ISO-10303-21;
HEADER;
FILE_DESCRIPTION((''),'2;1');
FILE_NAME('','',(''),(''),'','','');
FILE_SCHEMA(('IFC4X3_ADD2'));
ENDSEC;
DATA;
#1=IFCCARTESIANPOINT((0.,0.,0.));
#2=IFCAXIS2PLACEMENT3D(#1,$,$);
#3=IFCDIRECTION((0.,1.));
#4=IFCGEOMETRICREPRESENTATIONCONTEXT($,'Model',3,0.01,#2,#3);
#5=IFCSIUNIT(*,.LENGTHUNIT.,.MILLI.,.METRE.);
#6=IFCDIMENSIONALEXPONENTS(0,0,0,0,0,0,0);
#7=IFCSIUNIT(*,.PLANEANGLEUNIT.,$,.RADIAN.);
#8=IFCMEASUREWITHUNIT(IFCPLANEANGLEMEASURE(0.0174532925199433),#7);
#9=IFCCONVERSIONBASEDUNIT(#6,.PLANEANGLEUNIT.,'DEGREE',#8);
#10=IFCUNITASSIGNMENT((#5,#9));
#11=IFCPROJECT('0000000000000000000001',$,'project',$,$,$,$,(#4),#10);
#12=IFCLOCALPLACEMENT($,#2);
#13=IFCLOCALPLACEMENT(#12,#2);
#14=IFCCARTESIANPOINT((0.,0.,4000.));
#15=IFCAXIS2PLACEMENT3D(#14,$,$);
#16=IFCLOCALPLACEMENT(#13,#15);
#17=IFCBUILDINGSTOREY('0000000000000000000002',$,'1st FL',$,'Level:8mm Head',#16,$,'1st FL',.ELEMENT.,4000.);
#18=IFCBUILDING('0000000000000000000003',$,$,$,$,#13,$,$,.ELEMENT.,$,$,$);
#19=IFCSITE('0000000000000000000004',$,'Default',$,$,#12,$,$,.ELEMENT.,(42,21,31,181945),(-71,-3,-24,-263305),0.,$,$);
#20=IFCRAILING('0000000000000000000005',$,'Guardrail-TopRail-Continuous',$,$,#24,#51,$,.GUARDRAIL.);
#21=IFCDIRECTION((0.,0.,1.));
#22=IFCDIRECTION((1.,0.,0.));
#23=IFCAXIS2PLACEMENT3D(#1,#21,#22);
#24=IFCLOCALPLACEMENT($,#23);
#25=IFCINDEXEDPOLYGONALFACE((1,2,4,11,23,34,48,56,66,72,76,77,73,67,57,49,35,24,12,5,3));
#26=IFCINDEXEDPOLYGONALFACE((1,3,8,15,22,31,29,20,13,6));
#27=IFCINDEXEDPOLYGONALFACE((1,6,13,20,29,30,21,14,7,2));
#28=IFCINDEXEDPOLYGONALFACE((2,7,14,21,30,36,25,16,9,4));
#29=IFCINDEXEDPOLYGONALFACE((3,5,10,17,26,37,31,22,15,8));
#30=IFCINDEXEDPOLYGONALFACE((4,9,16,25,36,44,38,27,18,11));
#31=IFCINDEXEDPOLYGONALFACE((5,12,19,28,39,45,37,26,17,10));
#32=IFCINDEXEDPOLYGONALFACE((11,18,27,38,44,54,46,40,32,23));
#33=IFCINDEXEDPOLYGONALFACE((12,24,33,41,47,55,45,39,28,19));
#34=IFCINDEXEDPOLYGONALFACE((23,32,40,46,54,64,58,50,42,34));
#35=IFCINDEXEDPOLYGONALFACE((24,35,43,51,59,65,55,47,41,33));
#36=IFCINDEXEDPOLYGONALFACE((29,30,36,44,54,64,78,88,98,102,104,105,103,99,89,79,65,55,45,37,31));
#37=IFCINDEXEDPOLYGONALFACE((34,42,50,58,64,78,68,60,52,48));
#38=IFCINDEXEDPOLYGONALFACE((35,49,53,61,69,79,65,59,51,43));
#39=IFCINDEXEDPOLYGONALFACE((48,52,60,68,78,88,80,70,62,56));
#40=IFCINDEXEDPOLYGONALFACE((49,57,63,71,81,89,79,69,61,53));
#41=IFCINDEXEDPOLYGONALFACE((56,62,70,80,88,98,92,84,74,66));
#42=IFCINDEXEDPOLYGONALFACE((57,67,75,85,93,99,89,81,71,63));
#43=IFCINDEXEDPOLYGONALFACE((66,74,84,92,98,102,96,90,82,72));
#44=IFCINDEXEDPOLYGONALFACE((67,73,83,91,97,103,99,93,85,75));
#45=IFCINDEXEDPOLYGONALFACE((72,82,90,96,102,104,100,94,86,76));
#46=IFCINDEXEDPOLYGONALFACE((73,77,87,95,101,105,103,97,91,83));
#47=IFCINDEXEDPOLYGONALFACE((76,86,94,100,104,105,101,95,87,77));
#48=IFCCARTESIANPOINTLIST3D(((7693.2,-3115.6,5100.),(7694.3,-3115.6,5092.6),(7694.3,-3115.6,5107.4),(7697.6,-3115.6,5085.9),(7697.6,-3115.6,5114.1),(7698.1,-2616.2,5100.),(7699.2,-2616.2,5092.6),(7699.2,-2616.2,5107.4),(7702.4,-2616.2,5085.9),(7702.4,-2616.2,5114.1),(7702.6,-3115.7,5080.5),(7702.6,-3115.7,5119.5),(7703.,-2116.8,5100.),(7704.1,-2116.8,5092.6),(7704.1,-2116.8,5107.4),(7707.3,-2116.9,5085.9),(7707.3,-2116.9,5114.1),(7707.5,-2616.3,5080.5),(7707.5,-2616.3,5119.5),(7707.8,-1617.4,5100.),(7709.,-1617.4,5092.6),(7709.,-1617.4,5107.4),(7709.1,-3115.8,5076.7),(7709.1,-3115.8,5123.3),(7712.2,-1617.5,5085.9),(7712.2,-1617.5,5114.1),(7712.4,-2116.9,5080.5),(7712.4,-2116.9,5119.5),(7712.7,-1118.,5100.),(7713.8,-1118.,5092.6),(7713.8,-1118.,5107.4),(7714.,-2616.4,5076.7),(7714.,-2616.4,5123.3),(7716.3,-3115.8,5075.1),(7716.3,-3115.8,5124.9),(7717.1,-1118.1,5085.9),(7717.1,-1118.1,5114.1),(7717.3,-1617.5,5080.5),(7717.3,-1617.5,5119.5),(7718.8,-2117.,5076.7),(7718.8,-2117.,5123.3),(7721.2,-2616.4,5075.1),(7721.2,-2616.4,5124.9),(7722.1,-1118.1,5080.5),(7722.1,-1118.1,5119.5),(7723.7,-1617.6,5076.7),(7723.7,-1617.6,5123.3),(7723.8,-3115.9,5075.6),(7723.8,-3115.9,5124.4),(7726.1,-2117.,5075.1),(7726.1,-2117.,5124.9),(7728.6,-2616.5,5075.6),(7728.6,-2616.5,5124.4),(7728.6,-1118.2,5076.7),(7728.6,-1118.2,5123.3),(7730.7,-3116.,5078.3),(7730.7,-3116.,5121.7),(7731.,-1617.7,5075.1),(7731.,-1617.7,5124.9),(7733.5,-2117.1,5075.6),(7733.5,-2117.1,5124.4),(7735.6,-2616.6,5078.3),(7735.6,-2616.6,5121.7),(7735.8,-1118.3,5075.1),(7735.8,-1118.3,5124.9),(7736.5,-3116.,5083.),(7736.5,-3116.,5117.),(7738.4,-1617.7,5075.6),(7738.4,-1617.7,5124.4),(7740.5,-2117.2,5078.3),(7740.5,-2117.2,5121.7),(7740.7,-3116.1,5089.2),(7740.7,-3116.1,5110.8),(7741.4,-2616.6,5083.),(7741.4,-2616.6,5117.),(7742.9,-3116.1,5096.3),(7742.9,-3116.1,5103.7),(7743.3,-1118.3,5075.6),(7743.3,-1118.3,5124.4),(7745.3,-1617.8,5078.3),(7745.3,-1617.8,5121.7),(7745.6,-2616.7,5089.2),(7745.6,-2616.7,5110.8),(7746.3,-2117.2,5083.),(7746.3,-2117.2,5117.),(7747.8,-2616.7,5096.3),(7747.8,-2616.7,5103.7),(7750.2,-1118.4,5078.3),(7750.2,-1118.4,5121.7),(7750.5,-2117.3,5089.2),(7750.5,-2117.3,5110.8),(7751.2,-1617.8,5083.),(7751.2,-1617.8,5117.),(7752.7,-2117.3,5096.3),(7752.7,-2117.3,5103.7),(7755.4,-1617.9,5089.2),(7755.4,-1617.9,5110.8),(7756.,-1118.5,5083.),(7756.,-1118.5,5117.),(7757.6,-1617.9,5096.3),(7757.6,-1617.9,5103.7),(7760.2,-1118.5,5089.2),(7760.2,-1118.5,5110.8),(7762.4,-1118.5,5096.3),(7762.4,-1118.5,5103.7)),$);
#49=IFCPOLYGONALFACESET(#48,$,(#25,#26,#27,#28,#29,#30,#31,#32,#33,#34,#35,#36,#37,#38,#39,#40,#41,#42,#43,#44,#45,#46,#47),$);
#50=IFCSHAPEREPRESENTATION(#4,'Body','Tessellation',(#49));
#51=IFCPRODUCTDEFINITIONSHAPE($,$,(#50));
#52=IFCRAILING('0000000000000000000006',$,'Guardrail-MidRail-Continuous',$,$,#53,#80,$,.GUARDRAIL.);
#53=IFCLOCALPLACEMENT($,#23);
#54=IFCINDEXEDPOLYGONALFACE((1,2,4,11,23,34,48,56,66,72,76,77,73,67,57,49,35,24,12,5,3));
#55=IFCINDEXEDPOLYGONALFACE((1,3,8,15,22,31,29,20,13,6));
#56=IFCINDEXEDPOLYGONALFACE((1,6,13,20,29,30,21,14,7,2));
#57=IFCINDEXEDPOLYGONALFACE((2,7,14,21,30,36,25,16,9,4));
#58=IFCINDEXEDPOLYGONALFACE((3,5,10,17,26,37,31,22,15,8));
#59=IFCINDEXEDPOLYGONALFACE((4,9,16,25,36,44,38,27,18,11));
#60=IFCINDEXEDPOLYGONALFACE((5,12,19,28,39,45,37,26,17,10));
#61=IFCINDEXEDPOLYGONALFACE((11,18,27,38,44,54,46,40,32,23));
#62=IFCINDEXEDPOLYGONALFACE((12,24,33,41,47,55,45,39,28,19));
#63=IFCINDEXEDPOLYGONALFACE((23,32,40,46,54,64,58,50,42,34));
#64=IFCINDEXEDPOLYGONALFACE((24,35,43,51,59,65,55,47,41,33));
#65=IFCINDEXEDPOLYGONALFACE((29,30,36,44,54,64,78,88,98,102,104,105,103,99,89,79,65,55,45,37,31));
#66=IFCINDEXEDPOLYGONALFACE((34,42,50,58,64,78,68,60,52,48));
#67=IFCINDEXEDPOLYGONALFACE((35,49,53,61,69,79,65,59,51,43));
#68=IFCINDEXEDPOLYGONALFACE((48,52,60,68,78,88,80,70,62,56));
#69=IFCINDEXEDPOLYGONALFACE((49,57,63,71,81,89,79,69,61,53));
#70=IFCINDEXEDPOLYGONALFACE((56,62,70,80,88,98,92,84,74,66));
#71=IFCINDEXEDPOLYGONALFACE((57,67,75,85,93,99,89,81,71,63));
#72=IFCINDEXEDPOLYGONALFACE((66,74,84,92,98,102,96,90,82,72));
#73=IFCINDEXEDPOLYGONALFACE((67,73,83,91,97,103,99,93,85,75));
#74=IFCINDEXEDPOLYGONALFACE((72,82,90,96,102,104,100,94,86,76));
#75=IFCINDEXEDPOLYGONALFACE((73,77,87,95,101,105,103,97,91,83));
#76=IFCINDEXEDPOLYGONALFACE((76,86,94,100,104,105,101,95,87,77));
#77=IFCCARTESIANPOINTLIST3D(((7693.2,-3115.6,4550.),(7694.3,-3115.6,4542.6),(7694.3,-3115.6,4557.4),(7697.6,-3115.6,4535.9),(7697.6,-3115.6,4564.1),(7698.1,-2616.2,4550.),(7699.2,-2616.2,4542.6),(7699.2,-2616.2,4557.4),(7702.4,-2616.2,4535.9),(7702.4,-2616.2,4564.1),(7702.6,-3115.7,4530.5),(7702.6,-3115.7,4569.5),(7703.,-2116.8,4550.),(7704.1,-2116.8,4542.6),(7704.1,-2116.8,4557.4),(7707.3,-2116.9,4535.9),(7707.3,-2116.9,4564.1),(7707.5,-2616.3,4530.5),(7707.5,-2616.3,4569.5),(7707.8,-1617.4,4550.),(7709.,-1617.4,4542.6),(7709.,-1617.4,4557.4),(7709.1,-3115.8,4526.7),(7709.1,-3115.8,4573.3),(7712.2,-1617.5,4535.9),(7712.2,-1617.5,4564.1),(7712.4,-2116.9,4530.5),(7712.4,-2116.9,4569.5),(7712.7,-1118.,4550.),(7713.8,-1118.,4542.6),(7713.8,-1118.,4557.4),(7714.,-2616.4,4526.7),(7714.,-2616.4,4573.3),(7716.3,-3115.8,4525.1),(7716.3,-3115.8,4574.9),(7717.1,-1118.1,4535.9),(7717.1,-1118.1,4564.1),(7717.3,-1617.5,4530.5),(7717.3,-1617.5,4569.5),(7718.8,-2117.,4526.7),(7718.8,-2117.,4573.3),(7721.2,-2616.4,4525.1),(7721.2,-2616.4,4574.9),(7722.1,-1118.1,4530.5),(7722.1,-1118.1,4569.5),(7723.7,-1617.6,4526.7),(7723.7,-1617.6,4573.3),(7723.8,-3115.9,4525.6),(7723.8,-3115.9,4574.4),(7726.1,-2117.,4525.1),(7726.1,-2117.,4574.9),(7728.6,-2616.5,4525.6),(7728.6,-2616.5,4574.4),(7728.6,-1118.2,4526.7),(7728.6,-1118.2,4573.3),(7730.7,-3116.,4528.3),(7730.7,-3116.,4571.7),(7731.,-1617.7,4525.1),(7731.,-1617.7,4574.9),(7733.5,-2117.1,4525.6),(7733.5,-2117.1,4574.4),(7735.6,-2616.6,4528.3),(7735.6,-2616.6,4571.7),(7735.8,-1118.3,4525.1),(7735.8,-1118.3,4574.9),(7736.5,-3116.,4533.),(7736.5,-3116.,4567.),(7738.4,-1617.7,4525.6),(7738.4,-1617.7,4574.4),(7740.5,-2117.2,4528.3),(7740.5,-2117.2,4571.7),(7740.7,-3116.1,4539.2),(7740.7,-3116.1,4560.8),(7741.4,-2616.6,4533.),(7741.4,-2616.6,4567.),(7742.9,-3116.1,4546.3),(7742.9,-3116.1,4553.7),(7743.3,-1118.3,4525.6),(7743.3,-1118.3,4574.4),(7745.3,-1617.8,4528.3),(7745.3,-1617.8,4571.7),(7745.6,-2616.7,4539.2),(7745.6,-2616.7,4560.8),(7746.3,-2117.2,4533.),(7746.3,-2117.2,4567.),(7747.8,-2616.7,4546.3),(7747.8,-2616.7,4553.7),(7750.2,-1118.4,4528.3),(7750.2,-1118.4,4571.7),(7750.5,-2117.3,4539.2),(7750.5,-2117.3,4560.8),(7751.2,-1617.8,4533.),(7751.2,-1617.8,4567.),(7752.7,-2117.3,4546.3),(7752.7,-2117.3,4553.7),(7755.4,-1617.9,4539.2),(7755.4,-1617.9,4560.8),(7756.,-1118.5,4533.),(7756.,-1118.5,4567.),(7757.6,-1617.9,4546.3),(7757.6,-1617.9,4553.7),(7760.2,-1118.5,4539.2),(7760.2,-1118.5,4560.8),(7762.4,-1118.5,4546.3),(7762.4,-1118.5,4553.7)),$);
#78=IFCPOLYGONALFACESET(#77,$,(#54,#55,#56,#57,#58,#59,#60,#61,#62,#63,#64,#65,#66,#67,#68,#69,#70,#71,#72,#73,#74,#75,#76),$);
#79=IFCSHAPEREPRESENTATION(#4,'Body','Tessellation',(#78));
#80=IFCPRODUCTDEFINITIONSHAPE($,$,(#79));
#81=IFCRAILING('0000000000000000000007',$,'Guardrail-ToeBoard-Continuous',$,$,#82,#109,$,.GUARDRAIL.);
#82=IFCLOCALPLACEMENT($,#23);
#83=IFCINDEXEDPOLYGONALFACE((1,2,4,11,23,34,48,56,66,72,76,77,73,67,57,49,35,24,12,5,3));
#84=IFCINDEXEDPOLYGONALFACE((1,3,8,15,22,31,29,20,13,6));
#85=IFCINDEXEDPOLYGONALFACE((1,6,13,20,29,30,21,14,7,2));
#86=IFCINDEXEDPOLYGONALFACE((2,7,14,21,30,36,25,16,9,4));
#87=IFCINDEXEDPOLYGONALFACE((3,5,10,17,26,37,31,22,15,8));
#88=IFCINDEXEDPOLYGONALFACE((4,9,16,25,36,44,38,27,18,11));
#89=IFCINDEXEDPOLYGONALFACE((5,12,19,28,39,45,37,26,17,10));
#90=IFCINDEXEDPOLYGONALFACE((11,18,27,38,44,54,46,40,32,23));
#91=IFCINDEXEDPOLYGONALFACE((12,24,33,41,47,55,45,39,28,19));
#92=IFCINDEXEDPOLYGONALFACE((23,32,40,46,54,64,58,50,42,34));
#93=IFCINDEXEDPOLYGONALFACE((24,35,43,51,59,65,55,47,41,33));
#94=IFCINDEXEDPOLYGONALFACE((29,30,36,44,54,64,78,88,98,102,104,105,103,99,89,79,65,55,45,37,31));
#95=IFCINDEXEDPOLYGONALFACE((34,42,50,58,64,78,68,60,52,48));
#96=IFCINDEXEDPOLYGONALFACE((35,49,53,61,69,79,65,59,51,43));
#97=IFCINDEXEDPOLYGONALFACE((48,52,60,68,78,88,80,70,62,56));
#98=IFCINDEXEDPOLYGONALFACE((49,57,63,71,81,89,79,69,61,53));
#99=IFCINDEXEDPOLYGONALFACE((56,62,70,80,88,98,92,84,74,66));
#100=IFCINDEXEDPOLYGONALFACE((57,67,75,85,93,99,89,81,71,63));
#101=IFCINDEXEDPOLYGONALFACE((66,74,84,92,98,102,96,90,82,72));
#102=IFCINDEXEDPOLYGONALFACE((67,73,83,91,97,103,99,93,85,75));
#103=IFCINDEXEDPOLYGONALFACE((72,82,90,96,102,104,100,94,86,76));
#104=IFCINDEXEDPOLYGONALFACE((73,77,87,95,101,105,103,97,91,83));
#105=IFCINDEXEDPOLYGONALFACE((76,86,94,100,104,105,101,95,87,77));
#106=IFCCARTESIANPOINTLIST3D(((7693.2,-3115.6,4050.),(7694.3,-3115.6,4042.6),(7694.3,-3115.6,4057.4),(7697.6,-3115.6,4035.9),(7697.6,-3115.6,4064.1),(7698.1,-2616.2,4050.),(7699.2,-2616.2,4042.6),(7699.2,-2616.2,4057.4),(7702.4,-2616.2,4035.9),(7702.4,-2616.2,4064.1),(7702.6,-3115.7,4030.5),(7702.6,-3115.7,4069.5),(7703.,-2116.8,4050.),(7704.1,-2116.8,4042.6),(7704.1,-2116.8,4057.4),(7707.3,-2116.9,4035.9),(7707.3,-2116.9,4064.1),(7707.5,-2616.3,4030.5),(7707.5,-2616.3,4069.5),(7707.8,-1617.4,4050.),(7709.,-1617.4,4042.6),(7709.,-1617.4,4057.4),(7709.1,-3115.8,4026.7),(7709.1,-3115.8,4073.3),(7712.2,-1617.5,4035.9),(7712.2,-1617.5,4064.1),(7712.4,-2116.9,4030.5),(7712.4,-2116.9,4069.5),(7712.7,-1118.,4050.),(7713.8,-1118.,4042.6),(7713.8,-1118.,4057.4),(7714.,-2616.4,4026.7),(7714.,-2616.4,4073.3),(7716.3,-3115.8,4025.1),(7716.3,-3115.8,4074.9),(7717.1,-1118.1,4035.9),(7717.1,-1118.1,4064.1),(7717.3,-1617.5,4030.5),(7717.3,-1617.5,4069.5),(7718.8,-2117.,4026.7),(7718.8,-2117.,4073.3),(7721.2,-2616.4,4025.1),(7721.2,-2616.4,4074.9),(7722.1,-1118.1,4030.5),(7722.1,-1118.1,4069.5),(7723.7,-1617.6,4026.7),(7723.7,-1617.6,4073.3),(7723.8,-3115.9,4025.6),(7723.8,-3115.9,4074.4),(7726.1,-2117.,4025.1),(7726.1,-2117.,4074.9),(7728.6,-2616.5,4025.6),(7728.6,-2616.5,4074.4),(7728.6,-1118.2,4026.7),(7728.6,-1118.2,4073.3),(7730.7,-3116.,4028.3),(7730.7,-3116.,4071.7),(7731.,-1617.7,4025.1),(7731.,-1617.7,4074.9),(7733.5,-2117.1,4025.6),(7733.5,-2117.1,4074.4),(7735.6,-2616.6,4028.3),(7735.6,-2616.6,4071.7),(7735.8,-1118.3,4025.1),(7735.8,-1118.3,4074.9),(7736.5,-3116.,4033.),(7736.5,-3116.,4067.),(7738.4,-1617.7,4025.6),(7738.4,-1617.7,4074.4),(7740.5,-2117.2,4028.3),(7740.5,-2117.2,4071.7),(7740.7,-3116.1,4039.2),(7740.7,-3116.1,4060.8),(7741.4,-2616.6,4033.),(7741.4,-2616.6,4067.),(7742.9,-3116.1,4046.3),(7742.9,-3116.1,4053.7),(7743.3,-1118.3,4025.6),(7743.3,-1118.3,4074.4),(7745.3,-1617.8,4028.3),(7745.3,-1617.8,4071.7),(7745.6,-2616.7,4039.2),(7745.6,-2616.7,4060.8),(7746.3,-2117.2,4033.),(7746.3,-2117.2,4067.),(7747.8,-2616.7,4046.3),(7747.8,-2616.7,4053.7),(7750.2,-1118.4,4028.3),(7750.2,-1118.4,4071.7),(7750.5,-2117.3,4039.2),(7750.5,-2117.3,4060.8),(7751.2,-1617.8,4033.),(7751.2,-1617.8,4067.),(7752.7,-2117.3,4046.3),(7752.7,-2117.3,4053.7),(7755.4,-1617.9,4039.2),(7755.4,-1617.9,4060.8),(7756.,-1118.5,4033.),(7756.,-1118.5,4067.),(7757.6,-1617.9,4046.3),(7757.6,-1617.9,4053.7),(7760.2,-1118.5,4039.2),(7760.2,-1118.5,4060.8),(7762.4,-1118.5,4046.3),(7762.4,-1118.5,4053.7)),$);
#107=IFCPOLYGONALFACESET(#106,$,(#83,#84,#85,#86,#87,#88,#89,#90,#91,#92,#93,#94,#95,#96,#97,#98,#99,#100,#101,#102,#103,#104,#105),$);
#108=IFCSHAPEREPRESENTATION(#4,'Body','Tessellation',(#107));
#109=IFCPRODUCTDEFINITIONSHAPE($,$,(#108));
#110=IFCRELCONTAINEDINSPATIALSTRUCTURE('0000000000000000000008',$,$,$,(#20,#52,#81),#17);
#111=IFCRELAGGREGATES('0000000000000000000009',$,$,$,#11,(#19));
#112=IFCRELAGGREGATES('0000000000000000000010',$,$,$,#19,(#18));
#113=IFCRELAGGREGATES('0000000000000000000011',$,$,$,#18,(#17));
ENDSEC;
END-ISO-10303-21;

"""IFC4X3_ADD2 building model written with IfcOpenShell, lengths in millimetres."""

from ifc_helpers import new_model, entity, si_unit, converted_unit, direction, frame, origin, origin_with_axes, place, context, project, spatial, element, save


model = new_model("IFC4X3_ADD2")

# Units and contexts
model_context = context("Model", 3, precision=0.01, world=origin(), true_north=direction((0.0, 1.0)))
ifc_project = project(units=[si_unit("LENGTHUNIT", "METRE", prefix="MILLI"), converted_unit("PLANEANGLEUNIT", "DEGREE", entity("IfcPlaneAngleMeasure", 0.0174532925199433), si_unit("PLANEANGLEUNIT", "RADIAN"), dimensions=[0, 0, 0, 0, 0, 0, 0])], contexts=[model_context])

# Site, building, storey
site_placement = place(None, origin())
site = spatial("IfcSite", under=ifc_project, at=site_placement, Name="Default", CompositionType="ELEMENT", RefLatitude=(42, 21, 31, 181945), RefLongitude=(-71, -3, -24, -263305), RefElevation=0.0)
building_placement = place(site_placement, origin())
building = spatial("IfcBuilding", under=site, at=building_placement, CompositionType="ELEMENT")
storey_placement = place(building_placement, frame((0.0, 0.0, 4000.0)))
storey = spatial("IfcBuildingStorey", under=building, at=storey_placement, Name="1st FL", ObjectType="Level:8mm Head", LongName="1st FL", CompositionType="ELEMENT", Elevation=4000.0)

# Railings
railing_1_placement = place(None, origin_with_axes())
element("IfcRailing", 1, at=railing_1_placement, inside=storey, Name="Guardrail-TopRail-Continuous", PredefinedType="GUARDRAIL", context=model_context, shape_type="SweptSolid", body=[
    entity("IfcSweptDiskSolid", entity("IfcPolyline", [entity("IfcCartesianPoint", [7737.7, -1118.3, 5100.0]), entity("IfcCartesianPoint", [7732.8, -1617.7, 5100.0]), entity("IfcCartesianPoint", [7728.0, -2117.1, 5100.0]), entity("IfcCartesianPoint", [7723.1, -2616.5, 5100.0]), entity("IfcCartesianPoint", [7718.2, -3115.8, 5100.0])]), 25.0),
])
railing_2_placement = place(None, origin_with_axes())
element("IfcRailing", 2, at=railing_2_placement, inside=storey, Name="Guardrail-MidRail-Continuous", PredefinedType="GUARDRAIL", context=model_context, shape_type="SweptSolid", body=[
    entity("IfcSweptDiskSolid", entity("IfcPolyline", [entity("IfcCartesianPoint", [7737.7, -1118.3, 4550.0]), entity("IfcCartesianPoint", [7732.8, -1617.7, 4550.0]), entity("IfcCartesianPoint", [7728.0, -2117.1, 4550.0]), entity("IfcCartesianPoint", [7723.1, -2616.5, 4550.0]), entity("IfcCartesianPoint", [7718.2, -3115.8, 4550.0])]), 25.0),
])
railing_3_placement = place(None, origin_with_axes())
element("IfcRailing", 3, at=railing_3_placement, inside=storey, Name="Guardrail-ToeBoard-Continuous", PredefinedType="GUARDRAIL", context=model_context, shape_type="SweptSolid", body=[
    entity("IfcSweptDiskSolid", entity("IfcPolyline", [entity("IfcCartesianPoint", [7737.7, -1118.3, 4050.0]), entity("IfcCartesianPoint", [7732.8, -1617.7, 4050.0]), entity("IfcCartesianPoint", [7728.0, -2117.1, 4050.0]), entity("IfcCartesianPoint", [7723.1, -2616.5, 4050.0]), entity("IfcCartesianPoint", [7718.2, -3115.8, 4050.0])]), 25.0),
])

save(model, "model.ifc")
